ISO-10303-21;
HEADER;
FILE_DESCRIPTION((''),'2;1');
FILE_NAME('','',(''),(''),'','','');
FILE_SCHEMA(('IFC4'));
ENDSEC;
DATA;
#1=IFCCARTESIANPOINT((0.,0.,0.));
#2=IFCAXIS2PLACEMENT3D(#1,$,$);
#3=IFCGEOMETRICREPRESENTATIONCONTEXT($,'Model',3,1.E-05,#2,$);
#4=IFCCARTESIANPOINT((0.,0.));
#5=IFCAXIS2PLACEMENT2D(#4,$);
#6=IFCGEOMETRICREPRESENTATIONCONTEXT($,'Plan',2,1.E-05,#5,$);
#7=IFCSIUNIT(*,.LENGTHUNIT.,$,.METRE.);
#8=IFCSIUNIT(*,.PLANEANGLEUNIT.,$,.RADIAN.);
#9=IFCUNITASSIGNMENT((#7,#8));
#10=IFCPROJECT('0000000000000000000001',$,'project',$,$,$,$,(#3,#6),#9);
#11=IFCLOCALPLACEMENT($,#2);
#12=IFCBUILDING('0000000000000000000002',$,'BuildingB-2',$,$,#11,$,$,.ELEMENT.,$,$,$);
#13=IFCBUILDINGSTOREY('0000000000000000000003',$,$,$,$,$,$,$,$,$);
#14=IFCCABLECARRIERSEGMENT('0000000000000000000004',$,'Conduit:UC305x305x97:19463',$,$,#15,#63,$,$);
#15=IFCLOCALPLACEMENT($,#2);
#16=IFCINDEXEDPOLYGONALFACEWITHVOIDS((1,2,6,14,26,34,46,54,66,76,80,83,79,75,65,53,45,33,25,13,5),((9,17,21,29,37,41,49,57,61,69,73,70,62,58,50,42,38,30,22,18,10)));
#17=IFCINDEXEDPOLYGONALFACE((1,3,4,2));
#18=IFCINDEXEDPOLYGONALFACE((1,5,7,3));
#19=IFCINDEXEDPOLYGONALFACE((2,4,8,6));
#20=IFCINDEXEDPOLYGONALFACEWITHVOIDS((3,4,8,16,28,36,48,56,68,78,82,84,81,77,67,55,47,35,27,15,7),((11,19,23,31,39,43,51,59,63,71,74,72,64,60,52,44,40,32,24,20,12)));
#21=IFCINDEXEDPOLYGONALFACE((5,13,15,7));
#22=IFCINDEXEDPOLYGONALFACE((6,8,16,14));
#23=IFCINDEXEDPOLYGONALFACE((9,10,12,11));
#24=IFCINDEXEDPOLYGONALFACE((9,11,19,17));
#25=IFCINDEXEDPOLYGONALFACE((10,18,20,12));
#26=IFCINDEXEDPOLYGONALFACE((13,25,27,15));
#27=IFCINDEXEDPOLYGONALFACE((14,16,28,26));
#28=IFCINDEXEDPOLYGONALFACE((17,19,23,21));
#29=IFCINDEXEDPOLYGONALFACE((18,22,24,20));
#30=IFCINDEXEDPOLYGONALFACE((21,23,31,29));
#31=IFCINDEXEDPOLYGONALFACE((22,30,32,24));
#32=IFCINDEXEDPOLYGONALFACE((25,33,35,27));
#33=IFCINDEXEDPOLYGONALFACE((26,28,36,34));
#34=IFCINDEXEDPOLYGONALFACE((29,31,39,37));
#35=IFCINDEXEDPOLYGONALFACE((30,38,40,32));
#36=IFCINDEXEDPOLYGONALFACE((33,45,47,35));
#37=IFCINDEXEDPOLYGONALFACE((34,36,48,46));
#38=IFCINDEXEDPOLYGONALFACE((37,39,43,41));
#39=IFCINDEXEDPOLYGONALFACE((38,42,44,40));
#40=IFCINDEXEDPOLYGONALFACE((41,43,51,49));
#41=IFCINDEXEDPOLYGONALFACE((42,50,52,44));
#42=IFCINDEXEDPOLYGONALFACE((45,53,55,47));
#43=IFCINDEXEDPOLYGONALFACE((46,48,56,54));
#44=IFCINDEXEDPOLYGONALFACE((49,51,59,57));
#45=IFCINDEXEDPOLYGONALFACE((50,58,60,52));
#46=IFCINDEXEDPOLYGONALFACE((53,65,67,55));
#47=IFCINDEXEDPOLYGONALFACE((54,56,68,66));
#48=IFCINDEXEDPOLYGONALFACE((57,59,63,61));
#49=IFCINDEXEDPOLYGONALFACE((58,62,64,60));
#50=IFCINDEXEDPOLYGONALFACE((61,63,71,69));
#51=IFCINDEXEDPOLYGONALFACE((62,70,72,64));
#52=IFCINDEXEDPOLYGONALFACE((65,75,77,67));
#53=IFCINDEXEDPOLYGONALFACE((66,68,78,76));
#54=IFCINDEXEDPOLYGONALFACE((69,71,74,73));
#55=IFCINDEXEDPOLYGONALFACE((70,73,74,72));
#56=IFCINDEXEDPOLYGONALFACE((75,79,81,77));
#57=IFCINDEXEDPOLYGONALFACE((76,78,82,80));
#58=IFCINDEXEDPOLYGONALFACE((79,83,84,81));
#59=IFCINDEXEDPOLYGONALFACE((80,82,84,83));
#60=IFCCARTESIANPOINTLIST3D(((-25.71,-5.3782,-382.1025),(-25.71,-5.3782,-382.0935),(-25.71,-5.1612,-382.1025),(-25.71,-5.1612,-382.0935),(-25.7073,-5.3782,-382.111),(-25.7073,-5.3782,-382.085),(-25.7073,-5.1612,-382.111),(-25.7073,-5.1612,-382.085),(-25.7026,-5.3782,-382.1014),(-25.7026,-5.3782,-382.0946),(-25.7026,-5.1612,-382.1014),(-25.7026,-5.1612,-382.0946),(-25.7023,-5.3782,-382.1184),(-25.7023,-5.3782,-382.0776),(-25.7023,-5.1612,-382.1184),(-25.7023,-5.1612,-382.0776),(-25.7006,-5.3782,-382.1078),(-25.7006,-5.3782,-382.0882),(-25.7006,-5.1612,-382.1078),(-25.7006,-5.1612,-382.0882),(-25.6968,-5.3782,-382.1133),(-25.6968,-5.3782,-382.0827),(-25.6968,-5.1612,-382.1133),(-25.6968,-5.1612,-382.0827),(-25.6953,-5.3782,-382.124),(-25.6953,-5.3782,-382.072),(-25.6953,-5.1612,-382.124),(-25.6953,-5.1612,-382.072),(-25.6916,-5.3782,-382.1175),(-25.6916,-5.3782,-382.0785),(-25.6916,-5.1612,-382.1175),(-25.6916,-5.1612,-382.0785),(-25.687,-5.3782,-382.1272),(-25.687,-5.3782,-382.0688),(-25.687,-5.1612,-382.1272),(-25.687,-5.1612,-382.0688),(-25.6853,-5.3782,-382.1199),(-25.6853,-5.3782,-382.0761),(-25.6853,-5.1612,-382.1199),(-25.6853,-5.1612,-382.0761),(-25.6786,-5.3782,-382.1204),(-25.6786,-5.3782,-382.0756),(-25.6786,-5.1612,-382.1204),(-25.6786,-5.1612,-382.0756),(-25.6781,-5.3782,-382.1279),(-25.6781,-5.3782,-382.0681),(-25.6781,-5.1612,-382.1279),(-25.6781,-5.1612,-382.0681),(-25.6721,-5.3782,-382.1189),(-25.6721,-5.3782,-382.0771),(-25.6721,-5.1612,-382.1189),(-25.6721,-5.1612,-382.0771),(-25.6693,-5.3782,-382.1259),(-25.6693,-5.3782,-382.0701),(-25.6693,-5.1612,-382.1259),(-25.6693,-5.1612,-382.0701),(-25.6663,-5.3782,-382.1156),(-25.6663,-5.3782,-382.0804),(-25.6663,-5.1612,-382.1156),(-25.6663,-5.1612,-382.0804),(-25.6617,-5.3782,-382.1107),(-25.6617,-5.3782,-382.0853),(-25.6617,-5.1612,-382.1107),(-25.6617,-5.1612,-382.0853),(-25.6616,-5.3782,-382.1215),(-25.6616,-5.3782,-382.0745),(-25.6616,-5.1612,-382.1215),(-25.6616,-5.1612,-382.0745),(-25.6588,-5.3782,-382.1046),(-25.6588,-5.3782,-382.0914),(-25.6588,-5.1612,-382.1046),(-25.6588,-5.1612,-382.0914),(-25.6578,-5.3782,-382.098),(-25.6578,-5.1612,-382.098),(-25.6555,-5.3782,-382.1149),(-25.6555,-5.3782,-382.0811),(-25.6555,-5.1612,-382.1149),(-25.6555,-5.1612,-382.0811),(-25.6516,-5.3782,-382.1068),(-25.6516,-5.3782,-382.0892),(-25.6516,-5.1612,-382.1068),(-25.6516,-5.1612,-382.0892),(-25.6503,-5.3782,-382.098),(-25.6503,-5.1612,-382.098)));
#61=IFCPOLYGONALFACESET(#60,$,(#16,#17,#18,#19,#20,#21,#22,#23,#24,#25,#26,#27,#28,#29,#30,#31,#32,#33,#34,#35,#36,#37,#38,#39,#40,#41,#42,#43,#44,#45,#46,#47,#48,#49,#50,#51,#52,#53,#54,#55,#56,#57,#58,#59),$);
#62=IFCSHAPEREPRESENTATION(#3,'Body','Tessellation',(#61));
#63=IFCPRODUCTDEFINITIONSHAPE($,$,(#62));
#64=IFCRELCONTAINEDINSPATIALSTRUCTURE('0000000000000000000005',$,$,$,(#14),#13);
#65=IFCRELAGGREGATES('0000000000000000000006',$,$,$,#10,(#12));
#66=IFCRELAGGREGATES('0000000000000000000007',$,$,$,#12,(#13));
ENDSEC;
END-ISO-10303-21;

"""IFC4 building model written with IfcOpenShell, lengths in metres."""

from ifc_helpers import new_model, entity, si_unit, origin, origin_2d, place, context, project, spatial, element, save


model = new_model("IFC4")

# Units and contexts
model_context = context("Model", 3, precision=1e-05, world=origin())
plan_context = context("Plan", 2, precision=1e-05, world=origin_2d())
ifc_project = project(units=[si_unit("LENGTHUNIT", "METRE"), si_unit("PLANEANGLEUNIT", "RADIAN")], contexts=[model_context, plan_context])

# Building, storey
building_placement = place(None, origin())
building = spatial("IfcBuilding", under=ifc_project, at=building_placement, Name="BuildingB-2", CompositionType="ELEMENT")
storey = spatial("IfcBuildingStorey", under=building)

# Cable carrier segment
element("IfcCableCarrierSegment", 1, inside=storey, Name="Conduit:UC305x305x97:19463", context=model_context, shape_type="AdvancedSweptSolid", body=[
    entity("IfcSweptDiskSolid", entity("IfcCompositeCurve", [entity("IfcCompositeCurveSegment", "CONTINUOUS", False, entity("IfcPolyline", [entity("IfcCartesianPoint", [25.6803, 5.1612, 382.098]), entity("IfcCartesianPoint", [25.6803, 5.3782, 382.098])]))], False), 0.03, 0.0225),
])

save(model, "model.ifc")
